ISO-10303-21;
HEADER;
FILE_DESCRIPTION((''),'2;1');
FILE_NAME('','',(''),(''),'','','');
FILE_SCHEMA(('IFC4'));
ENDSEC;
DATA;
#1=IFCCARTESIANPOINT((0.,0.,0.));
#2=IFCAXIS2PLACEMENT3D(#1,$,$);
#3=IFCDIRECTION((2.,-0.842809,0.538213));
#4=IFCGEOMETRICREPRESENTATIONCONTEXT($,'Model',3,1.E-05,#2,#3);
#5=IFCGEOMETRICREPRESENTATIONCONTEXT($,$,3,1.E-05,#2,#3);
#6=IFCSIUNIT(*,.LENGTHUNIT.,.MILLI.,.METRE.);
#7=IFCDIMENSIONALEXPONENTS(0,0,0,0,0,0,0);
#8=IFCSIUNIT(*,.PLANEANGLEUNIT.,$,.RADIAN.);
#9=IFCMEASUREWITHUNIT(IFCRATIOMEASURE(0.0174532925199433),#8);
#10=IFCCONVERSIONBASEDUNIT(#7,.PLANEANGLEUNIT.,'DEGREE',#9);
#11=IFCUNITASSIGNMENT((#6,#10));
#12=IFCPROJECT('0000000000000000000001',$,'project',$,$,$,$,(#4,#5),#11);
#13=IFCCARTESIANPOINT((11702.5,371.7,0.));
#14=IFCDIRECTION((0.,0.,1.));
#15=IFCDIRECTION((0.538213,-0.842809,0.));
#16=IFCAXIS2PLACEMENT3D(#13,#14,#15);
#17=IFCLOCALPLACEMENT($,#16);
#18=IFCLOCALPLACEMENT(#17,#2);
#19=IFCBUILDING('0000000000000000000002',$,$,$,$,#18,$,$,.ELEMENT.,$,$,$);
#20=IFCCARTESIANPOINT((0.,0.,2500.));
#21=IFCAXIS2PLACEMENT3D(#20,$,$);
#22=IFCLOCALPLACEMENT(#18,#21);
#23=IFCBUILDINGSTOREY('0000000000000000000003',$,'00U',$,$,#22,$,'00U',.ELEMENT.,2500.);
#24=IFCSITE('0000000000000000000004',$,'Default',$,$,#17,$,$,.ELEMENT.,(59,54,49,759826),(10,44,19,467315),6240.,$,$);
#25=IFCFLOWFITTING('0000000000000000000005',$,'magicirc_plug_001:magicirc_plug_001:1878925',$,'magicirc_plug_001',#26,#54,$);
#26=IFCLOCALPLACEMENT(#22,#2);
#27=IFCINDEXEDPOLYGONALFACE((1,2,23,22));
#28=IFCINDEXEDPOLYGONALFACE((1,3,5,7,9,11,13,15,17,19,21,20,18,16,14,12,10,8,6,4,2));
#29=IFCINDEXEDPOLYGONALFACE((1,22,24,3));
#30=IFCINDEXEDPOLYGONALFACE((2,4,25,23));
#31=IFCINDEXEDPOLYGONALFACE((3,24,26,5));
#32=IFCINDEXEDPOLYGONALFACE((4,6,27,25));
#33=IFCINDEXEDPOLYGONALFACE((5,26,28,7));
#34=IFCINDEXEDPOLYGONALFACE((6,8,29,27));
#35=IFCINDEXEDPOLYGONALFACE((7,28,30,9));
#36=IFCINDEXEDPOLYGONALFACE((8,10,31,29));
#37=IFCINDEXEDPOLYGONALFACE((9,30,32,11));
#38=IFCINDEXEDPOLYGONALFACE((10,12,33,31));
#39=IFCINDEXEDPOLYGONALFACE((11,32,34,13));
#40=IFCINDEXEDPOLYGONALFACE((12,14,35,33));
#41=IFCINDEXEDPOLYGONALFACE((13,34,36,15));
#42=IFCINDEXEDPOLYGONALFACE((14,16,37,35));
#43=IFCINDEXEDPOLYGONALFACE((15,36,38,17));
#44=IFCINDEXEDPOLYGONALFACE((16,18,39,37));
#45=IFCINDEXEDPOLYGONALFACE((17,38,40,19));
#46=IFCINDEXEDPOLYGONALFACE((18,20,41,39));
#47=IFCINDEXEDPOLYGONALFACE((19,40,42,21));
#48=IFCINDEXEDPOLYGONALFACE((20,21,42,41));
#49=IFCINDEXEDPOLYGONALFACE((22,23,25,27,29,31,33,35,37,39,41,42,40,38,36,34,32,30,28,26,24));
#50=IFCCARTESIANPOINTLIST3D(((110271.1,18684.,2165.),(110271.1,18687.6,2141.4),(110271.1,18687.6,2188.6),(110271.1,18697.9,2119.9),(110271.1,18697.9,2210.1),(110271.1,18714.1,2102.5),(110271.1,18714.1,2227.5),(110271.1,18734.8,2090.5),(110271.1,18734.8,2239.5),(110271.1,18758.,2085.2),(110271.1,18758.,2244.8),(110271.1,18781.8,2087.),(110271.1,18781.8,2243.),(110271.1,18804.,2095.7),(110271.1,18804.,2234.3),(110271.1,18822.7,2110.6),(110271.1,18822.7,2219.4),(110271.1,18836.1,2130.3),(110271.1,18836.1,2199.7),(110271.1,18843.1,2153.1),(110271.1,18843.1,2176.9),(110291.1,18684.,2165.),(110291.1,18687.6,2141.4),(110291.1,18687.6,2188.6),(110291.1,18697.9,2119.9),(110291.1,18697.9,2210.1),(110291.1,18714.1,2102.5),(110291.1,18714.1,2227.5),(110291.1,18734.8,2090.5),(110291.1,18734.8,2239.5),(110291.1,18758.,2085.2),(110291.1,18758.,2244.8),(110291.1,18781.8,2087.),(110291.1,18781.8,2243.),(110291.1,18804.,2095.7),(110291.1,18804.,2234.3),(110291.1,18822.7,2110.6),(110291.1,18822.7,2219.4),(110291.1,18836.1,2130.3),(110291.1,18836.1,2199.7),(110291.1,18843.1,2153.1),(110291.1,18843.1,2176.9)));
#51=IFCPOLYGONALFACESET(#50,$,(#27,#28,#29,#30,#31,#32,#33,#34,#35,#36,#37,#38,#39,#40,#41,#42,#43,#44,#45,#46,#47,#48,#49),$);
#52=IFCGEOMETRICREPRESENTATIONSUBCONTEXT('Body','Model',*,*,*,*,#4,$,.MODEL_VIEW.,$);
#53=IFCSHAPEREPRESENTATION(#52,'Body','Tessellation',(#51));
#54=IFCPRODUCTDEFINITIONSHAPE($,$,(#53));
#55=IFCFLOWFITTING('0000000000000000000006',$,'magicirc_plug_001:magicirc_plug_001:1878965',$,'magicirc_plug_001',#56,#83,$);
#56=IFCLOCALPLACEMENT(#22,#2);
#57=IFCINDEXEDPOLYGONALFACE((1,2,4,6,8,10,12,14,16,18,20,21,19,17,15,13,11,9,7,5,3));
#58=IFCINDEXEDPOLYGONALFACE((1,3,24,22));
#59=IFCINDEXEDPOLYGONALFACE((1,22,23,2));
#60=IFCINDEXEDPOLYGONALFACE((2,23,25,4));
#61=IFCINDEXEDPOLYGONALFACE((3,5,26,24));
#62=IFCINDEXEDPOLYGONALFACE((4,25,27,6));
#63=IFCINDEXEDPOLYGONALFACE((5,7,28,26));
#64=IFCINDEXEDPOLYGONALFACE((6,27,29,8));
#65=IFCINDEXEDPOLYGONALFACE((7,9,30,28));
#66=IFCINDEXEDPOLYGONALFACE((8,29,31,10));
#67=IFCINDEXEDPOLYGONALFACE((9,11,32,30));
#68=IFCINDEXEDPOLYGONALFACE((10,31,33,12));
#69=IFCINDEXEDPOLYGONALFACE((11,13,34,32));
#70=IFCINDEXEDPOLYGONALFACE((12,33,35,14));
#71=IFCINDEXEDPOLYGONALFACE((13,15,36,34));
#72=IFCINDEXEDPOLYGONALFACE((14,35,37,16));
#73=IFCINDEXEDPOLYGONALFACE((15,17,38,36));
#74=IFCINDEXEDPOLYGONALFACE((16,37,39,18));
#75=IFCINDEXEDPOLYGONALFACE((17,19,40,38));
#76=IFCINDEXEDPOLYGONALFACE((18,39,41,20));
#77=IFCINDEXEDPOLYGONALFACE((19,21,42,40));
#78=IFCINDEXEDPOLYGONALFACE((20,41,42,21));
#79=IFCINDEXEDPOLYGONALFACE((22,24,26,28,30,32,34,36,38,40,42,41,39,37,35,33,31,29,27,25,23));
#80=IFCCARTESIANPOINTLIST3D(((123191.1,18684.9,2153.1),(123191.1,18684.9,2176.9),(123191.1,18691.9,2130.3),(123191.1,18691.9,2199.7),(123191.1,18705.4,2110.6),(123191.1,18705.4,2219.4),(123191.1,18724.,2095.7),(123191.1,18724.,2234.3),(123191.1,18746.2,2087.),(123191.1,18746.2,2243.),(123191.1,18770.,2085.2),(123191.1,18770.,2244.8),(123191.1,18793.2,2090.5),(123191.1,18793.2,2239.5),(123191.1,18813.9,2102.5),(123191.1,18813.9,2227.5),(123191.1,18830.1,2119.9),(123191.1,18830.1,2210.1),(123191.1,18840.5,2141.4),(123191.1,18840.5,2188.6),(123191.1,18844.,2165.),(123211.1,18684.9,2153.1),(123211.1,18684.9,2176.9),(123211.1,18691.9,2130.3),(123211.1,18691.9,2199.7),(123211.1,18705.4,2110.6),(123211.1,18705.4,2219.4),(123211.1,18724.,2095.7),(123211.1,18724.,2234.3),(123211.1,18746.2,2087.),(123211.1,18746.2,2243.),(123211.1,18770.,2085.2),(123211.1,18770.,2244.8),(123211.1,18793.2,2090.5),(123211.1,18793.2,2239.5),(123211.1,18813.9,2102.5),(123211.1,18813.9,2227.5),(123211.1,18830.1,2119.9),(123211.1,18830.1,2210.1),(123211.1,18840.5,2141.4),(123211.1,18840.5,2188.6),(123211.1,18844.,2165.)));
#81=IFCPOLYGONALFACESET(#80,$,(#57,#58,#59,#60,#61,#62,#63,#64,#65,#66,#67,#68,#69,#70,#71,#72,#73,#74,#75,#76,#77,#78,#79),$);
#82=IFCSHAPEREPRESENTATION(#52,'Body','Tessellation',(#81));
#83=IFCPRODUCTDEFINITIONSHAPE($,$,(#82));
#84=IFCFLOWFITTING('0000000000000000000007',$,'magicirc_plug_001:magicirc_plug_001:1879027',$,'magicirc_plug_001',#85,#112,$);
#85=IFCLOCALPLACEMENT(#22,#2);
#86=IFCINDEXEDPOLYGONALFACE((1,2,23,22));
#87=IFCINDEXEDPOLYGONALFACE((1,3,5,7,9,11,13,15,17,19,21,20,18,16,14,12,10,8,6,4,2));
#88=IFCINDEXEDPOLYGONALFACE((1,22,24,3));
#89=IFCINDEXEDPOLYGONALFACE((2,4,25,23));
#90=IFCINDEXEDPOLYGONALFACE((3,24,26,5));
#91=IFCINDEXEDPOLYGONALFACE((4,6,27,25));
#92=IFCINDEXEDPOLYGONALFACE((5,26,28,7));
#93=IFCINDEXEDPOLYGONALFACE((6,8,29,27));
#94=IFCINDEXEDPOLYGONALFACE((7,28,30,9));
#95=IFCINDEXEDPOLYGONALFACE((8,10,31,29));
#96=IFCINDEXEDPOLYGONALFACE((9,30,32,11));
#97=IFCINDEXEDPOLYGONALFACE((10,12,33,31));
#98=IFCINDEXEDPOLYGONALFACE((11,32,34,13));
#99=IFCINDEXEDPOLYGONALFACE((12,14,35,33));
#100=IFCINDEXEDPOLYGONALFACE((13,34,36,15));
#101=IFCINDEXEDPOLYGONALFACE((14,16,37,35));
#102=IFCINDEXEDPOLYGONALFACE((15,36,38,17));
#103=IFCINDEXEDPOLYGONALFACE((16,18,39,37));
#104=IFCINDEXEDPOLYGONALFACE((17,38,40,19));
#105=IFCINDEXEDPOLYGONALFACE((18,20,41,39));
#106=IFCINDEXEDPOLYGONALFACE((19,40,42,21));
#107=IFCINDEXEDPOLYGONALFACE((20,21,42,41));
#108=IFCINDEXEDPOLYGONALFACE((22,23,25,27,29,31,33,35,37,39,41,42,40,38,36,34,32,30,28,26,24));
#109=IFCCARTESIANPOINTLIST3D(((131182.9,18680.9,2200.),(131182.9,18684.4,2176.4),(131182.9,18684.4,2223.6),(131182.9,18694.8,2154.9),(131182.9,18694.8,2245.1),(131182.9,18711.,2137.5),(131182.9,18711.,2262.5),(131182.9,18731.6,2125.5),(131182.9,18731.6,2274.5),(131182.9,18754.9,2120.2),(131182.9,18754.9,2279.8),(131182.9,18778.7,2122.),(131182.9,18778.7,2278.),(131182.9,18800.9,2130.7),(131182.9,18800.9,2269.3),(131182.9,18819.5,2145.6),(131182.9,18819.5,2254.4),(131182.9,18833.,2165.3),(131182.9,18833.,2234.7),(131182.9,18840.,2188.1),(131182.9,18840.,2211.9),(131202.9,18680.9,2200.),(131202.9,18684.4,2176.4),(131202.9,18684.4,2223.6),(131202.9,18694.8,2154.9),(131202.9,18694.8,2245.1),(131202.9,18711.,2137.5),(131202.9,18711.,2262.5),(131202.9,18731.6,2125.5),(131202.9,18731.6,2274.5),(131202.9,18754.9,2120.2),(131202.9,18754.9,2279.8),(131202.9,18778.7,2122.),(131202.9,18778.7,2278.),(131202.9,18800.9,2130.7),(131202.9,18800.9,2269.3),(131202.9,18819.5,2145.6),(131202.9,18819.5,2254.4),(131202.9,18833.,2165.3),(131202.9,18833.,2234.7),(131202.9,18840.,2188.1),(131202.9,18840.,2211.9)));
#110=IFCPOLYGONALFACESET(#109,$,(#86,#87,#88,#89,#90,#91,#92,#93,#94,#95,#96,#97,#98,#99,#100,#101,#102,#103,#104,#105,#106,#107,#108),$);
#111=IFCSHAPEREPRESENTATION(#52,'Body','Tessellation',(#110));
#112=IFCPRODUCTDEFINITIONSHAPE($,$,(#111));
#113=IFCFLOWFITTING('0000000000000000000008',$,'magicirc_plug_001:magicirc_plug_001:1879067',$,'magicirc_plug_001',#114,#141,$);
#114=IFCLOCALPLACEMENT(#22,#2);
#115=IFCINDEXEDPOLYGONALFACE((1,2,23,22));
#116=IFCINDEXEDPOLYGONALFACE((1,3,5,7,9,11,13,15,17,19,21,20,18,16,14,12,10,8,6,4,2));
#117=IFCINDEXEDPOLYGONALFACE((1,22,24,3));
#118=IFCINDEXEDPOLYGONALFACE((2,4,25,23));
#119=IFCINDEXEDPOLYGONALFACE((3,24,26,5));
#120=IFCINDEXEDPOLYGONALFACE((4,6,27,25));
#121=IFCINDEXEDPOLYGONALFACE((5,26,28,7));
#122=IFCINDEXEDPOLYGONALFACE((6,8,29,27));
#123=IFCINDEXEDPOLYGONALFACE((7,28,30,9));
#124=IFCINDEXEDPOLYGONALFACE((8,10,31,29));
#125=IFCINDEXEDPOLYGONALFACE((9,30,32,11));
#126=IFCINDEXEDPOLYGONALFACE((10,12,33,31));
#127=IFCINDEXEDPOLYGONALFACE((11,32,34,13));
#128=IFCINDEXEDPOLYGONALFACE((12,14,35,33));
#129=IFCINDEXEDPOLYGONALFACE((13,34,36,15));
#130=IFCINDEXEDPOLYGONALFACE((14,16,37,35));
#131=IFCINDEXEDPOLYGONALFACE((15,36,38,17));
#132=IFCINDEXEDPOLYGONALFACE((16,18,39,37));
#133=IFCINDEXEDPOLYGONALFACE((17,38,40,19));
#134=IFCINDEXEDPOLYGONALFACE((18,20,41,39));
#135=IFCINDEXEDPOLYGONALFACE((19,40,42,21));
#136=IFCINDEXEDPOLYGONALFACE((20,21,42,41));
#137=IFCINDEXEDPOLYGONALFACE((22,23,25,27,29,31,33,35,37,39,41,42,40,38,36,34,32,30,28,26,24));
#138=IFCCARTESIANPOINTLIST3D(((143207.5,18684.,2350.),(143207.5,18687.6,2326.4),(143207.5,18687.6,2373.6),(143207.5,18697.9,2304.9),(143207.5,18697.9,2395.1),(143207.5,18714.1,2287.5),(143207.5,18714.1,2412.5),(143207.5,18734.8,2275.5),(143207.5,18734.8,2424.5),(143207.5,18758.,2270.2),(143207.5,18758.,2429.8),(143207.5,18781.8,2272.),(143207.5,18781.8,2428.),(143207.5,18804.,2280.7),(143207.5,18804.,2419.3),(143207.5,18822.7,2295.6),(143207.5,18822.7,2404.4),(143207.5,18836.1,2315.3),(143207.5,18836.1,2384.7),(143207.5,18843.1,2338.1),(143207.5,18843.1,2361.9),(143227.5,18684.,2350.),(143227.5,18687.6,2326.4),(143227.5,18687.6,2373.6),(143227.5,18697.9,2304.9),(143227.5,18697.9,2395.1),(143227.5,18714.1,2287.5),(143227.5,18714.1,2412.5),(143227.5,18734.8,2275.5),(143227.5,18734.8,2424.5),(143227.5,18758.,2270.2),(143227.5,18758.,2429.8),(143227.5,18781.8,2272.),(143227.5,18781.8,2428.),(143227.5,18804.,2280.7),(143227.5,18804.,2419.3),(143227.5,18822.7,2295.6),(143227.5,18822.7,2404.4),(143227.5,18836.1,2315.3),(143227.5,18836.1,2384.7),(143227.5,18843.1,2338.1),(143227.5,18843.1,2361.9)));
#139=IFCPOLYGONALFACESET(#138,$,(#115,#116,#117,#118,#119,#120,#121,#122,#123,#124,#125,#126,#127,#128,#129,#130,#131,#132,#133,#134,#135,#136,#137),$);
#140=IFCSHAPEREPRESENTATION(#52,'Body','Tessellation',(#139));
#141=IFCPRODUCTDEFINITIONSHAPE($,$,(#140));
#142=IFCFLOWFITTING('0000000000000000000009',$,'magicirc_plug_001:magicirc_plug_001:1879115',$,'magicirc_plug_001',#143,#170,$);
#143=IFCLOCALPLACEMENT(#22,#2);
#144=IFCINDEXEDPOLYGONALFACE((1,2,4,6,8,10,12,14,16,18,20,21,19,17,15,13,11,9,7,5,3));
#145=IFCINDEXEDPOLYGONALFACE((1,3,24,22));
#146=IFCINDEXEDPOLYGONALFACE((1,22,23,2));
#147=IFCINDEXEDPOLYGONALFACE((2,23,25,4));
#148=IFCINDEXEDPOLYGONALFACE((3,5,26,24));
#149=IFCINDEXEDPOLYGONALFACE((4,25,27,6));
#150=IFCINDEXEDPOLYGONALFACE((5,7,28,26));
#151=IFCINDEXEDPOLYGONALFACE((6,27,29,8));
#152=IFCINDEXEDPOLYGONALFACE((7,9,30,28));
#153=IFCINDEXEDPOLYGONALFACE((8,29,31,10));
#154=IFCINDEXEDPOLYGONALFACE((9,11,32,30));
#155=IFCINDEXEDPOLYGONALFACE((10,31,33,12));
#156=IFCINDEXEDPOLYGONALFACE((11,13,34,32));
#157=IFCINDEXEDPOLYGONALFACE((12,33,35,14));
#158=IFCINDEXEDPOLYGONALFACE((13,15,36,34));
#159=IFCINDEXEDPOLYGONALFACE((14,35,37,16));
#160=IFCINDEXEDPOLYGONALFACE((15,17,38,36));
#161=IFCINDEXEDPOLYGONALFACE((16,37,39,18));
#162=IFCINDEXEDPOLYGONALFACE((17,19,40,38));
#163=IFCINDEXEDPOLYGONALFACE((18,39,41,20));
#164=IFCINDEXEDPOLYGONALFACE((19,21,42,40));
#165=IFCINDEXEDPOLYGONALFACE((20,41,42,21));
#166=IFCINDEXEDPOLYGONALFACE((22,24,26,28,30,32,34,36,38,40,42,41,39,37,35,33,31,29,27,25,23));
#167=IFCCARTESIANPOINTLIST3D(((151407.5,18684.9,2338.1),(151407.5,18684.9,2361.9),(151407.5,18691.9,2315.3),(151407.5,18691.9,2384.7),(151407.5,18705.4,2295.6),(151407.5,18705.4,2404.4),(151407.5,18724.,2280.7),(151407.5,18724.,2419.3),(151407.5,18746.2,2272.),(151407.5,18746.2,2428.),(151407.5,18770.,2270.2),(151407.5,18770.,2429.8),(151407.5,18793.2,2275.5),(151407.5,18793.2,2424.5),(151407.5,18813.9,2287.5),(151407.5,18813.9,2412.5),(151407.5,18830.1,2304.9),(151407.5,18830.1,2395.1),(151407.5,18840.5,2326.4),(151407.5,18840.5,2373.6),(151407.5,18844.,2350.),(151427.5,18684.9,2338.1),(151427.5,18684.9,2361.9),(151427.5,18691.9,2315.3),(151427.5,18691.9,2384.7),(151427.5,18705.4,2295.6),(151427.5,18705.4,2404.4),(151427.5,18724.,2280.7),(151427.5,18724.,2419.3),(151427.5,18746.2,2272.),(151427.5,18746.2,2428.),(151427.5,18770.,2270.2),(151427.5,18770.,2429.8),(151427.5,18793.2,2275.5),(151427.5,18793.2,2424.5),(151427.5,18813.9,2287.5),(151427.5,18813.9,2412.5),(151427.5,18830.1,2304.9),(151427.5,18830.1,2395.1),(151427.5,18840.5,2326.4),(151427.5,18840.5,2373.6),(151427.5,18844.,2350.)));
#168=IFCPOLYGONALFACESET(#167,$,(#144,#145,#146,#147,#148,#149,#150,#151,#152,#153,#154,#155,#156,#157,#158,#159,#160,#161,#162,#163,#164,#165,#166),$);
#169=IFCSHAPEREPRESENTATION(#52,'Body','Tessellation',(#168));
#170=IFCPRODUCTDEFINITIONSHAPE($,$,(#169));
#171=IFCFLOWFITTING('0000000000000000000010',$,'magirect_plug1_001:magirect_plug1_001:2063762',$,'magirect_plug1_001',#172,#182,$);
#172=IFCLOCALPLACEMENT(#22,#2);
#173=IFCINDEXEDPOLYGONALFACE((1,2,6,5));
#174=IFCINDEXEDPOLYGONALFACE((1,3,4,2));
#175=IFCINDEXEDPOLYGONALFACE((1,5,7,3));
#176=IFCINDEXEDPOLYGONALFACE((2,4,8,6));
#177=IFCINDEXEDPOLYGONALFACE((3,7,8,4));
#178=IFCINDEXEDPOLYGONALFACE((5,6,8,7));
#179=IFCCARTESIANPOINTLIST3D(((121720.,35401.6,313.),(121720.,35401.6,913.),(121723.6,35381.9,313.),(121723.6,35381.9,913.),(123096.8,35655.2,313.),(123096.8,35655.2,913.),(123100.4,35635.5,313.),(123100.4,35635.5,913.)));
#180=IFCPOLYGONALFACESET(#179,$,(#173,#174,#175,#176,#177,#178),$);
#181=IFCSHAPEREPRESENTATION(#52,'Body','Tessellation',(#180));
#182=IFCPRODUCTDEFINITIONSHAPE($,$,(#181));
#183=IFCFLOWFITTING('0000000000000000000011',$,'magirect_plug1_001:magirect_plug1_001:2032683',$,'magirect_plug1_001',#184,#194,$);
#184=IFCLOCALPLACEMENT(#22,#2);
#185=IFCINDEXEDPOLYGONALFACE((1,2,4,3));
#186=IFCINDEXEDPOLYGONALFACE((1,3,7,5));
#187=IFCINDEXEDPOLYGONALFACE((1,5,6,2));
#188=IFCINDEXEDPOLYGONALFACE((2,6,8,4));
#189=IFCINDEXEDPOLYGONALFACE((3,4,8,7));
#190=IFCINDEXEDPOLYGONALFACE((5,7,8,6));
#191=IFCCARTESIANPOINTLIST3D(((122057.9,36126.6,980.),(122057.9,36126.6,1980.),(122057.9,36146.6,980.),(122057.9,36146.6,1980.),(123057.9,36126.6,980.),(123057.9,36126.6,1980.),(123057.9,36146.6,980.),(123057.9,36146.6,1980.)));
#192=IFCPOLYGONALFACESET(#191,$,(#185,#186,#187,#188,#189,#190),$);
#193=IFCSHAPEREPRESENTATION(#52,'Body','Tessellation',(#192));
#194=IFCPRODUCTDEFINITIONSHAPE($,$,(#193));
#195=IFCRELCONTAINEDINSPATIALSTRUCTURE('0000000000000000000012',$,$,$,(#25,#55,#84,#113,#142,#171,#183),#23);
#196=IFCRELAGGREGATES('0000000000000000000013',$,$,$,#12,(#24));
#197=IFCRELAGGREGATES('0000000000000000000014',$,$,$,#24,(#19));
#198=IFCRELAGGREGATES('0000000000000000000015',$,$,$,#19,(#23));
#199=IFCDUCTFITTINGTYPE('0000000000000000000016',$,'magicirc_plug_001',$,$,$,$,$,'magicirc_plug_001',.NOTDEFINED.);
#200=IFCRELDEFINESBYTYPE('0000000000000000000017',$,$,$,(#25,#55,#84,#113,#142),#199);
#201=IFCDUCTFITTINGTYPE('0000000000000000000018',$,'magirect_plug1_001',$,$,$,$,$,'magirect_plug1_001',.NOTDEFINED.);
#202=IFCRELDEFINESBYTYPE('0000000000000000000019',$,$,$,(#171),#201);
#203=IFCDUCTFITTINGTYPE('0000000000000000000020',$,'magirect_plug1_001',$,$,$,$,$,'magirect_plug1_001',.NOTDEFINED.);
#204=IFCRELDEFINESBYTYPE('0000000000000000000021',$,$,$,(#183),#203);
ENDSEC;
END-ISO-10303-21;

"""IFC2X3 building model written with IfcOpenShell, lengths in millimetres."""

from ifc_helpers import new_model, entity, si_unit, converted_unit, direction, frame, frame_2d, origin, place, context, subcontext, project, spatial, rectangle, circle, extrude, source, transform, mapped, type_object, type_shapes, element, save


model = new_model("IFC2X3")

# Units and contexts
model_context = context("Model", 3, precision=1e-05, world=origin(), true_north=direction((2.0, -0.842809, 0.538213)))
context_of_model = context(None, 3, precision=1e-05, world=origin(), true_north=direction((2.0, -0.842809, 0.538213)))
body_context = subcontext(model_context, "Body", "Model", "MODEL_VIEW")
ifc_project = project(units=[si_unit("LENGTHUNIT", "METRE", prefix="MILLI"), converted_unit("PLANEANGLEUNIT", "DEGREE", entity("IfcRatioMeasure", 0.0174532925199433), si_unit("PLANEANGLEUNIT", "RADIAN"), dimensions=[0, 0, 0, 0, 0, 0, 0])], contexts=[model_context, context_of_model])

# Site, building, storey
site_placement = place(None, frame((11702.5, 371.7, 0.0), z_axis=(0.0, 0.0, 1.0), x_axis=(0.538213, -0.842809, 0.0)))
site = spatial("IfcSite", under=ifc_project, at=site_placement, Name="Default", CompositionType="ELEMENT", RefLatitude=(59, 54, 49, 759826), RefLongitude=(10, 44, 19, 467315), RefElevation=6240.0)
building_placement = place(site_placement, origin())
building = spatial("IfcBuilding", under=site, at=building_placement, CompositionType="ELEMENT")
storey_placement = place(building_placement, frame((0.0, 0.0, 2500.0)))
storey = spatial("IfcBuildingStorey", under=building, at=storey_placement, Name="00U", LongName="00U", CompositionType="ELEMENT", Elevation=2500.0)

# Flow fittings
duct_fitting_type_1 = type_object("IfcDuctFittingType", Name="magicirc_plug_001", ElementType="magicirc_plug_001", PredefinedType="NOTDEFINED")
shared_shape_1 = source(origin(), body_context, "Body", "SweptSolid", [
    extrude(circle(Radius=80.0, at=frame_2d((0.0, 0.0), x_axis=(1.0, 0.0))), frame((0.0, 0.0, 0.0), z_axis=(1.0, 0.0, 0.0), x_axis=(0.0, 1.0, 0.0)), (0.0, 0.0, 1.0), 20.0),
])
type_shapes(duct_fitting_type_1, [shared_shape_1])
flow_fitting_1_placement = place(storey_placement, frame((110291.1, 18764.0, 2165.0), z_axis=(0.0, 0.0, 1.0), x_axis=(-1.0, 0.0, 0.0)))
element("IfcFlowFitting", 1, at=flow_fitting_1_placement, inside=storey, type_object=duct_fitting_type_1, Name="magicirc_plug_001:magicirc_plug_001:1878925", ObjectType="magicirc_plug_001", context=body_context, shape_type="MappedRepresentation", body=[
    mapped(shared_shape_1, transform((0.0, 0.0, 0.0), scale=1.0)),
])
flow_fitting_2_placement = place(storey_placement, frame((123191.1, 18764.0, 2165.0)))
element("IfcFlowFitting", 2, at=flow_fitting_2_placement, inside=storey, type_object=duct_fitting_type_1, Name="magicirc_plug_001:magicirc_plug_001:1878965", ObjectType="magicirc_plug_001", context=body_context, shape_type="MappedRepresentation", body=[
    mapped(shared_shape_1, transform((0.0, 0.0, 0.0), scale=1.0)),
])
for number, where, z_axis, x_axis, name in (
    (3, (131202.9, 18760.9, 2200.0), (0.0, 0.0, 1.0), (-1.0, 0.0, 0.0), "magicirc_plug_001:magicirc_plug_001:1879027"),
    (4, (143227.5, 18764.0, 2350.0), (0.0, 0.0, 1.0), (-1.0, 0.0, 0.0), "magicirc_plug_001:magicirc_plug_001:1879067"),
):
    element("IfcFlowFitting", number, at=place(storey_placement, frame(where, z_axis=z_axis, x_axis=x_axis)), inside=storey, type_object=duct_fitting_type_1, Name=name, ObjectType="magicirc_plug_001", context=body_context, shape_type="MappedRepresentation", body=[
        mapped(shared_shape_1, transform((0.0, 0.0, 0.0), scale=1.0)),
    ])
flow_fitting_3_placement = place(storey_placement, frame((151407.5, 18764.0, 2350.0)))
element("IfcFlowFitting", 5, at=flow_fitting_3_placement, inside=storey, type_object=duct_fitting_type_1, Name="magicirc_plug_001:magicirc_plug_001:1879115", ObjectType="magicirc_plug_001", context=body_context, shape_type="MappedRepresentation", body=[
    mapped(shared_shape_1, transform((0.0, 0.0, 0.0), scale=1.0)),
])
duct_fitting_type_2 = type_object("IfcDuctFittingType", Name="magirect_plug1_001", ElementType="magirect_plug1_001", PredefinedType="NOTDEFINED")
shared_shape_2 = source(origin(), body_context, "Body", "SweptSolid", [
    extrude(rectangle(XDim=20.0, YDim=1400.0, at=frame_2d((0.0, 0.0), x_axis=(1.0, 0.0))), frame((10.0, 0.0, -300.0)), (0.0, 0.0, 1.0), 600.0),
])
type_shapes(duct_fitting_type_2, [shared_shape_2])
flow_fitting_4_placement = place(storey_placement, frame((122408.4, 35528.4, 613.0), z_axis=(0.0, 0.0, 1.0), x_axis=(0.18117, -0.983452, 0.0)))
element("IfcFlowFitting", 6, at=flow_fitting_4_placement, inside=storey, type_object=duct_fitting_type_2, Name="magirect_plug1_001:magirect_plug1_001:2063762", ObjectType="magirect_plug1_001", context=body_context, shape_type="MappedRepresentation", body=[
    mapped(shared_shape_2, transform((0.0, 0.0, 0.0), scale=1.0)),
])
duct_fitting_type_3 = type_object("IfcDuctFittingType", Name="magirect_plug1_001", ElementType="magirect_plug1_001", PredefinedType="NOTDEFINED")
shared_shape_3 = source(origin(), body_context, "Body", "SweptSolid", [
    extrude(rectangle(XDim=20.0, YDim=1000.0, at=frame_2d((0.0, 0.0), x_axis=(1.0, 0.0))), frame((10.0, 0.0, -500.0)), (0.0, 0.0, 1.0), 1000.0),
])
type_shapes(duct_fitting_type_3, [shared_shape_3])
flow_fitting_5_placement = place(storey_placement, frame((122557.9, 36126.6, 1480.0), z_axis=(0.0, 0.0, 1.0), x_axis=(0.0, 1.0, 0.0)))
element("IfcFlowFitting", 7, at=flow_fitting_5_placement, inside=storey, type_object=duct_fitting_type_3, Name="magirect_plug1_001:magirect_plug1_001:2032683", ObjectType="magirect_plug1_001", context=body_context, shape_type="MappedRepresentation", body=[
    mapped(shared_shape_3, transform((0.0, 0.0, 0.0), scale=1.0)),
])

save(model, "model.ifc")
